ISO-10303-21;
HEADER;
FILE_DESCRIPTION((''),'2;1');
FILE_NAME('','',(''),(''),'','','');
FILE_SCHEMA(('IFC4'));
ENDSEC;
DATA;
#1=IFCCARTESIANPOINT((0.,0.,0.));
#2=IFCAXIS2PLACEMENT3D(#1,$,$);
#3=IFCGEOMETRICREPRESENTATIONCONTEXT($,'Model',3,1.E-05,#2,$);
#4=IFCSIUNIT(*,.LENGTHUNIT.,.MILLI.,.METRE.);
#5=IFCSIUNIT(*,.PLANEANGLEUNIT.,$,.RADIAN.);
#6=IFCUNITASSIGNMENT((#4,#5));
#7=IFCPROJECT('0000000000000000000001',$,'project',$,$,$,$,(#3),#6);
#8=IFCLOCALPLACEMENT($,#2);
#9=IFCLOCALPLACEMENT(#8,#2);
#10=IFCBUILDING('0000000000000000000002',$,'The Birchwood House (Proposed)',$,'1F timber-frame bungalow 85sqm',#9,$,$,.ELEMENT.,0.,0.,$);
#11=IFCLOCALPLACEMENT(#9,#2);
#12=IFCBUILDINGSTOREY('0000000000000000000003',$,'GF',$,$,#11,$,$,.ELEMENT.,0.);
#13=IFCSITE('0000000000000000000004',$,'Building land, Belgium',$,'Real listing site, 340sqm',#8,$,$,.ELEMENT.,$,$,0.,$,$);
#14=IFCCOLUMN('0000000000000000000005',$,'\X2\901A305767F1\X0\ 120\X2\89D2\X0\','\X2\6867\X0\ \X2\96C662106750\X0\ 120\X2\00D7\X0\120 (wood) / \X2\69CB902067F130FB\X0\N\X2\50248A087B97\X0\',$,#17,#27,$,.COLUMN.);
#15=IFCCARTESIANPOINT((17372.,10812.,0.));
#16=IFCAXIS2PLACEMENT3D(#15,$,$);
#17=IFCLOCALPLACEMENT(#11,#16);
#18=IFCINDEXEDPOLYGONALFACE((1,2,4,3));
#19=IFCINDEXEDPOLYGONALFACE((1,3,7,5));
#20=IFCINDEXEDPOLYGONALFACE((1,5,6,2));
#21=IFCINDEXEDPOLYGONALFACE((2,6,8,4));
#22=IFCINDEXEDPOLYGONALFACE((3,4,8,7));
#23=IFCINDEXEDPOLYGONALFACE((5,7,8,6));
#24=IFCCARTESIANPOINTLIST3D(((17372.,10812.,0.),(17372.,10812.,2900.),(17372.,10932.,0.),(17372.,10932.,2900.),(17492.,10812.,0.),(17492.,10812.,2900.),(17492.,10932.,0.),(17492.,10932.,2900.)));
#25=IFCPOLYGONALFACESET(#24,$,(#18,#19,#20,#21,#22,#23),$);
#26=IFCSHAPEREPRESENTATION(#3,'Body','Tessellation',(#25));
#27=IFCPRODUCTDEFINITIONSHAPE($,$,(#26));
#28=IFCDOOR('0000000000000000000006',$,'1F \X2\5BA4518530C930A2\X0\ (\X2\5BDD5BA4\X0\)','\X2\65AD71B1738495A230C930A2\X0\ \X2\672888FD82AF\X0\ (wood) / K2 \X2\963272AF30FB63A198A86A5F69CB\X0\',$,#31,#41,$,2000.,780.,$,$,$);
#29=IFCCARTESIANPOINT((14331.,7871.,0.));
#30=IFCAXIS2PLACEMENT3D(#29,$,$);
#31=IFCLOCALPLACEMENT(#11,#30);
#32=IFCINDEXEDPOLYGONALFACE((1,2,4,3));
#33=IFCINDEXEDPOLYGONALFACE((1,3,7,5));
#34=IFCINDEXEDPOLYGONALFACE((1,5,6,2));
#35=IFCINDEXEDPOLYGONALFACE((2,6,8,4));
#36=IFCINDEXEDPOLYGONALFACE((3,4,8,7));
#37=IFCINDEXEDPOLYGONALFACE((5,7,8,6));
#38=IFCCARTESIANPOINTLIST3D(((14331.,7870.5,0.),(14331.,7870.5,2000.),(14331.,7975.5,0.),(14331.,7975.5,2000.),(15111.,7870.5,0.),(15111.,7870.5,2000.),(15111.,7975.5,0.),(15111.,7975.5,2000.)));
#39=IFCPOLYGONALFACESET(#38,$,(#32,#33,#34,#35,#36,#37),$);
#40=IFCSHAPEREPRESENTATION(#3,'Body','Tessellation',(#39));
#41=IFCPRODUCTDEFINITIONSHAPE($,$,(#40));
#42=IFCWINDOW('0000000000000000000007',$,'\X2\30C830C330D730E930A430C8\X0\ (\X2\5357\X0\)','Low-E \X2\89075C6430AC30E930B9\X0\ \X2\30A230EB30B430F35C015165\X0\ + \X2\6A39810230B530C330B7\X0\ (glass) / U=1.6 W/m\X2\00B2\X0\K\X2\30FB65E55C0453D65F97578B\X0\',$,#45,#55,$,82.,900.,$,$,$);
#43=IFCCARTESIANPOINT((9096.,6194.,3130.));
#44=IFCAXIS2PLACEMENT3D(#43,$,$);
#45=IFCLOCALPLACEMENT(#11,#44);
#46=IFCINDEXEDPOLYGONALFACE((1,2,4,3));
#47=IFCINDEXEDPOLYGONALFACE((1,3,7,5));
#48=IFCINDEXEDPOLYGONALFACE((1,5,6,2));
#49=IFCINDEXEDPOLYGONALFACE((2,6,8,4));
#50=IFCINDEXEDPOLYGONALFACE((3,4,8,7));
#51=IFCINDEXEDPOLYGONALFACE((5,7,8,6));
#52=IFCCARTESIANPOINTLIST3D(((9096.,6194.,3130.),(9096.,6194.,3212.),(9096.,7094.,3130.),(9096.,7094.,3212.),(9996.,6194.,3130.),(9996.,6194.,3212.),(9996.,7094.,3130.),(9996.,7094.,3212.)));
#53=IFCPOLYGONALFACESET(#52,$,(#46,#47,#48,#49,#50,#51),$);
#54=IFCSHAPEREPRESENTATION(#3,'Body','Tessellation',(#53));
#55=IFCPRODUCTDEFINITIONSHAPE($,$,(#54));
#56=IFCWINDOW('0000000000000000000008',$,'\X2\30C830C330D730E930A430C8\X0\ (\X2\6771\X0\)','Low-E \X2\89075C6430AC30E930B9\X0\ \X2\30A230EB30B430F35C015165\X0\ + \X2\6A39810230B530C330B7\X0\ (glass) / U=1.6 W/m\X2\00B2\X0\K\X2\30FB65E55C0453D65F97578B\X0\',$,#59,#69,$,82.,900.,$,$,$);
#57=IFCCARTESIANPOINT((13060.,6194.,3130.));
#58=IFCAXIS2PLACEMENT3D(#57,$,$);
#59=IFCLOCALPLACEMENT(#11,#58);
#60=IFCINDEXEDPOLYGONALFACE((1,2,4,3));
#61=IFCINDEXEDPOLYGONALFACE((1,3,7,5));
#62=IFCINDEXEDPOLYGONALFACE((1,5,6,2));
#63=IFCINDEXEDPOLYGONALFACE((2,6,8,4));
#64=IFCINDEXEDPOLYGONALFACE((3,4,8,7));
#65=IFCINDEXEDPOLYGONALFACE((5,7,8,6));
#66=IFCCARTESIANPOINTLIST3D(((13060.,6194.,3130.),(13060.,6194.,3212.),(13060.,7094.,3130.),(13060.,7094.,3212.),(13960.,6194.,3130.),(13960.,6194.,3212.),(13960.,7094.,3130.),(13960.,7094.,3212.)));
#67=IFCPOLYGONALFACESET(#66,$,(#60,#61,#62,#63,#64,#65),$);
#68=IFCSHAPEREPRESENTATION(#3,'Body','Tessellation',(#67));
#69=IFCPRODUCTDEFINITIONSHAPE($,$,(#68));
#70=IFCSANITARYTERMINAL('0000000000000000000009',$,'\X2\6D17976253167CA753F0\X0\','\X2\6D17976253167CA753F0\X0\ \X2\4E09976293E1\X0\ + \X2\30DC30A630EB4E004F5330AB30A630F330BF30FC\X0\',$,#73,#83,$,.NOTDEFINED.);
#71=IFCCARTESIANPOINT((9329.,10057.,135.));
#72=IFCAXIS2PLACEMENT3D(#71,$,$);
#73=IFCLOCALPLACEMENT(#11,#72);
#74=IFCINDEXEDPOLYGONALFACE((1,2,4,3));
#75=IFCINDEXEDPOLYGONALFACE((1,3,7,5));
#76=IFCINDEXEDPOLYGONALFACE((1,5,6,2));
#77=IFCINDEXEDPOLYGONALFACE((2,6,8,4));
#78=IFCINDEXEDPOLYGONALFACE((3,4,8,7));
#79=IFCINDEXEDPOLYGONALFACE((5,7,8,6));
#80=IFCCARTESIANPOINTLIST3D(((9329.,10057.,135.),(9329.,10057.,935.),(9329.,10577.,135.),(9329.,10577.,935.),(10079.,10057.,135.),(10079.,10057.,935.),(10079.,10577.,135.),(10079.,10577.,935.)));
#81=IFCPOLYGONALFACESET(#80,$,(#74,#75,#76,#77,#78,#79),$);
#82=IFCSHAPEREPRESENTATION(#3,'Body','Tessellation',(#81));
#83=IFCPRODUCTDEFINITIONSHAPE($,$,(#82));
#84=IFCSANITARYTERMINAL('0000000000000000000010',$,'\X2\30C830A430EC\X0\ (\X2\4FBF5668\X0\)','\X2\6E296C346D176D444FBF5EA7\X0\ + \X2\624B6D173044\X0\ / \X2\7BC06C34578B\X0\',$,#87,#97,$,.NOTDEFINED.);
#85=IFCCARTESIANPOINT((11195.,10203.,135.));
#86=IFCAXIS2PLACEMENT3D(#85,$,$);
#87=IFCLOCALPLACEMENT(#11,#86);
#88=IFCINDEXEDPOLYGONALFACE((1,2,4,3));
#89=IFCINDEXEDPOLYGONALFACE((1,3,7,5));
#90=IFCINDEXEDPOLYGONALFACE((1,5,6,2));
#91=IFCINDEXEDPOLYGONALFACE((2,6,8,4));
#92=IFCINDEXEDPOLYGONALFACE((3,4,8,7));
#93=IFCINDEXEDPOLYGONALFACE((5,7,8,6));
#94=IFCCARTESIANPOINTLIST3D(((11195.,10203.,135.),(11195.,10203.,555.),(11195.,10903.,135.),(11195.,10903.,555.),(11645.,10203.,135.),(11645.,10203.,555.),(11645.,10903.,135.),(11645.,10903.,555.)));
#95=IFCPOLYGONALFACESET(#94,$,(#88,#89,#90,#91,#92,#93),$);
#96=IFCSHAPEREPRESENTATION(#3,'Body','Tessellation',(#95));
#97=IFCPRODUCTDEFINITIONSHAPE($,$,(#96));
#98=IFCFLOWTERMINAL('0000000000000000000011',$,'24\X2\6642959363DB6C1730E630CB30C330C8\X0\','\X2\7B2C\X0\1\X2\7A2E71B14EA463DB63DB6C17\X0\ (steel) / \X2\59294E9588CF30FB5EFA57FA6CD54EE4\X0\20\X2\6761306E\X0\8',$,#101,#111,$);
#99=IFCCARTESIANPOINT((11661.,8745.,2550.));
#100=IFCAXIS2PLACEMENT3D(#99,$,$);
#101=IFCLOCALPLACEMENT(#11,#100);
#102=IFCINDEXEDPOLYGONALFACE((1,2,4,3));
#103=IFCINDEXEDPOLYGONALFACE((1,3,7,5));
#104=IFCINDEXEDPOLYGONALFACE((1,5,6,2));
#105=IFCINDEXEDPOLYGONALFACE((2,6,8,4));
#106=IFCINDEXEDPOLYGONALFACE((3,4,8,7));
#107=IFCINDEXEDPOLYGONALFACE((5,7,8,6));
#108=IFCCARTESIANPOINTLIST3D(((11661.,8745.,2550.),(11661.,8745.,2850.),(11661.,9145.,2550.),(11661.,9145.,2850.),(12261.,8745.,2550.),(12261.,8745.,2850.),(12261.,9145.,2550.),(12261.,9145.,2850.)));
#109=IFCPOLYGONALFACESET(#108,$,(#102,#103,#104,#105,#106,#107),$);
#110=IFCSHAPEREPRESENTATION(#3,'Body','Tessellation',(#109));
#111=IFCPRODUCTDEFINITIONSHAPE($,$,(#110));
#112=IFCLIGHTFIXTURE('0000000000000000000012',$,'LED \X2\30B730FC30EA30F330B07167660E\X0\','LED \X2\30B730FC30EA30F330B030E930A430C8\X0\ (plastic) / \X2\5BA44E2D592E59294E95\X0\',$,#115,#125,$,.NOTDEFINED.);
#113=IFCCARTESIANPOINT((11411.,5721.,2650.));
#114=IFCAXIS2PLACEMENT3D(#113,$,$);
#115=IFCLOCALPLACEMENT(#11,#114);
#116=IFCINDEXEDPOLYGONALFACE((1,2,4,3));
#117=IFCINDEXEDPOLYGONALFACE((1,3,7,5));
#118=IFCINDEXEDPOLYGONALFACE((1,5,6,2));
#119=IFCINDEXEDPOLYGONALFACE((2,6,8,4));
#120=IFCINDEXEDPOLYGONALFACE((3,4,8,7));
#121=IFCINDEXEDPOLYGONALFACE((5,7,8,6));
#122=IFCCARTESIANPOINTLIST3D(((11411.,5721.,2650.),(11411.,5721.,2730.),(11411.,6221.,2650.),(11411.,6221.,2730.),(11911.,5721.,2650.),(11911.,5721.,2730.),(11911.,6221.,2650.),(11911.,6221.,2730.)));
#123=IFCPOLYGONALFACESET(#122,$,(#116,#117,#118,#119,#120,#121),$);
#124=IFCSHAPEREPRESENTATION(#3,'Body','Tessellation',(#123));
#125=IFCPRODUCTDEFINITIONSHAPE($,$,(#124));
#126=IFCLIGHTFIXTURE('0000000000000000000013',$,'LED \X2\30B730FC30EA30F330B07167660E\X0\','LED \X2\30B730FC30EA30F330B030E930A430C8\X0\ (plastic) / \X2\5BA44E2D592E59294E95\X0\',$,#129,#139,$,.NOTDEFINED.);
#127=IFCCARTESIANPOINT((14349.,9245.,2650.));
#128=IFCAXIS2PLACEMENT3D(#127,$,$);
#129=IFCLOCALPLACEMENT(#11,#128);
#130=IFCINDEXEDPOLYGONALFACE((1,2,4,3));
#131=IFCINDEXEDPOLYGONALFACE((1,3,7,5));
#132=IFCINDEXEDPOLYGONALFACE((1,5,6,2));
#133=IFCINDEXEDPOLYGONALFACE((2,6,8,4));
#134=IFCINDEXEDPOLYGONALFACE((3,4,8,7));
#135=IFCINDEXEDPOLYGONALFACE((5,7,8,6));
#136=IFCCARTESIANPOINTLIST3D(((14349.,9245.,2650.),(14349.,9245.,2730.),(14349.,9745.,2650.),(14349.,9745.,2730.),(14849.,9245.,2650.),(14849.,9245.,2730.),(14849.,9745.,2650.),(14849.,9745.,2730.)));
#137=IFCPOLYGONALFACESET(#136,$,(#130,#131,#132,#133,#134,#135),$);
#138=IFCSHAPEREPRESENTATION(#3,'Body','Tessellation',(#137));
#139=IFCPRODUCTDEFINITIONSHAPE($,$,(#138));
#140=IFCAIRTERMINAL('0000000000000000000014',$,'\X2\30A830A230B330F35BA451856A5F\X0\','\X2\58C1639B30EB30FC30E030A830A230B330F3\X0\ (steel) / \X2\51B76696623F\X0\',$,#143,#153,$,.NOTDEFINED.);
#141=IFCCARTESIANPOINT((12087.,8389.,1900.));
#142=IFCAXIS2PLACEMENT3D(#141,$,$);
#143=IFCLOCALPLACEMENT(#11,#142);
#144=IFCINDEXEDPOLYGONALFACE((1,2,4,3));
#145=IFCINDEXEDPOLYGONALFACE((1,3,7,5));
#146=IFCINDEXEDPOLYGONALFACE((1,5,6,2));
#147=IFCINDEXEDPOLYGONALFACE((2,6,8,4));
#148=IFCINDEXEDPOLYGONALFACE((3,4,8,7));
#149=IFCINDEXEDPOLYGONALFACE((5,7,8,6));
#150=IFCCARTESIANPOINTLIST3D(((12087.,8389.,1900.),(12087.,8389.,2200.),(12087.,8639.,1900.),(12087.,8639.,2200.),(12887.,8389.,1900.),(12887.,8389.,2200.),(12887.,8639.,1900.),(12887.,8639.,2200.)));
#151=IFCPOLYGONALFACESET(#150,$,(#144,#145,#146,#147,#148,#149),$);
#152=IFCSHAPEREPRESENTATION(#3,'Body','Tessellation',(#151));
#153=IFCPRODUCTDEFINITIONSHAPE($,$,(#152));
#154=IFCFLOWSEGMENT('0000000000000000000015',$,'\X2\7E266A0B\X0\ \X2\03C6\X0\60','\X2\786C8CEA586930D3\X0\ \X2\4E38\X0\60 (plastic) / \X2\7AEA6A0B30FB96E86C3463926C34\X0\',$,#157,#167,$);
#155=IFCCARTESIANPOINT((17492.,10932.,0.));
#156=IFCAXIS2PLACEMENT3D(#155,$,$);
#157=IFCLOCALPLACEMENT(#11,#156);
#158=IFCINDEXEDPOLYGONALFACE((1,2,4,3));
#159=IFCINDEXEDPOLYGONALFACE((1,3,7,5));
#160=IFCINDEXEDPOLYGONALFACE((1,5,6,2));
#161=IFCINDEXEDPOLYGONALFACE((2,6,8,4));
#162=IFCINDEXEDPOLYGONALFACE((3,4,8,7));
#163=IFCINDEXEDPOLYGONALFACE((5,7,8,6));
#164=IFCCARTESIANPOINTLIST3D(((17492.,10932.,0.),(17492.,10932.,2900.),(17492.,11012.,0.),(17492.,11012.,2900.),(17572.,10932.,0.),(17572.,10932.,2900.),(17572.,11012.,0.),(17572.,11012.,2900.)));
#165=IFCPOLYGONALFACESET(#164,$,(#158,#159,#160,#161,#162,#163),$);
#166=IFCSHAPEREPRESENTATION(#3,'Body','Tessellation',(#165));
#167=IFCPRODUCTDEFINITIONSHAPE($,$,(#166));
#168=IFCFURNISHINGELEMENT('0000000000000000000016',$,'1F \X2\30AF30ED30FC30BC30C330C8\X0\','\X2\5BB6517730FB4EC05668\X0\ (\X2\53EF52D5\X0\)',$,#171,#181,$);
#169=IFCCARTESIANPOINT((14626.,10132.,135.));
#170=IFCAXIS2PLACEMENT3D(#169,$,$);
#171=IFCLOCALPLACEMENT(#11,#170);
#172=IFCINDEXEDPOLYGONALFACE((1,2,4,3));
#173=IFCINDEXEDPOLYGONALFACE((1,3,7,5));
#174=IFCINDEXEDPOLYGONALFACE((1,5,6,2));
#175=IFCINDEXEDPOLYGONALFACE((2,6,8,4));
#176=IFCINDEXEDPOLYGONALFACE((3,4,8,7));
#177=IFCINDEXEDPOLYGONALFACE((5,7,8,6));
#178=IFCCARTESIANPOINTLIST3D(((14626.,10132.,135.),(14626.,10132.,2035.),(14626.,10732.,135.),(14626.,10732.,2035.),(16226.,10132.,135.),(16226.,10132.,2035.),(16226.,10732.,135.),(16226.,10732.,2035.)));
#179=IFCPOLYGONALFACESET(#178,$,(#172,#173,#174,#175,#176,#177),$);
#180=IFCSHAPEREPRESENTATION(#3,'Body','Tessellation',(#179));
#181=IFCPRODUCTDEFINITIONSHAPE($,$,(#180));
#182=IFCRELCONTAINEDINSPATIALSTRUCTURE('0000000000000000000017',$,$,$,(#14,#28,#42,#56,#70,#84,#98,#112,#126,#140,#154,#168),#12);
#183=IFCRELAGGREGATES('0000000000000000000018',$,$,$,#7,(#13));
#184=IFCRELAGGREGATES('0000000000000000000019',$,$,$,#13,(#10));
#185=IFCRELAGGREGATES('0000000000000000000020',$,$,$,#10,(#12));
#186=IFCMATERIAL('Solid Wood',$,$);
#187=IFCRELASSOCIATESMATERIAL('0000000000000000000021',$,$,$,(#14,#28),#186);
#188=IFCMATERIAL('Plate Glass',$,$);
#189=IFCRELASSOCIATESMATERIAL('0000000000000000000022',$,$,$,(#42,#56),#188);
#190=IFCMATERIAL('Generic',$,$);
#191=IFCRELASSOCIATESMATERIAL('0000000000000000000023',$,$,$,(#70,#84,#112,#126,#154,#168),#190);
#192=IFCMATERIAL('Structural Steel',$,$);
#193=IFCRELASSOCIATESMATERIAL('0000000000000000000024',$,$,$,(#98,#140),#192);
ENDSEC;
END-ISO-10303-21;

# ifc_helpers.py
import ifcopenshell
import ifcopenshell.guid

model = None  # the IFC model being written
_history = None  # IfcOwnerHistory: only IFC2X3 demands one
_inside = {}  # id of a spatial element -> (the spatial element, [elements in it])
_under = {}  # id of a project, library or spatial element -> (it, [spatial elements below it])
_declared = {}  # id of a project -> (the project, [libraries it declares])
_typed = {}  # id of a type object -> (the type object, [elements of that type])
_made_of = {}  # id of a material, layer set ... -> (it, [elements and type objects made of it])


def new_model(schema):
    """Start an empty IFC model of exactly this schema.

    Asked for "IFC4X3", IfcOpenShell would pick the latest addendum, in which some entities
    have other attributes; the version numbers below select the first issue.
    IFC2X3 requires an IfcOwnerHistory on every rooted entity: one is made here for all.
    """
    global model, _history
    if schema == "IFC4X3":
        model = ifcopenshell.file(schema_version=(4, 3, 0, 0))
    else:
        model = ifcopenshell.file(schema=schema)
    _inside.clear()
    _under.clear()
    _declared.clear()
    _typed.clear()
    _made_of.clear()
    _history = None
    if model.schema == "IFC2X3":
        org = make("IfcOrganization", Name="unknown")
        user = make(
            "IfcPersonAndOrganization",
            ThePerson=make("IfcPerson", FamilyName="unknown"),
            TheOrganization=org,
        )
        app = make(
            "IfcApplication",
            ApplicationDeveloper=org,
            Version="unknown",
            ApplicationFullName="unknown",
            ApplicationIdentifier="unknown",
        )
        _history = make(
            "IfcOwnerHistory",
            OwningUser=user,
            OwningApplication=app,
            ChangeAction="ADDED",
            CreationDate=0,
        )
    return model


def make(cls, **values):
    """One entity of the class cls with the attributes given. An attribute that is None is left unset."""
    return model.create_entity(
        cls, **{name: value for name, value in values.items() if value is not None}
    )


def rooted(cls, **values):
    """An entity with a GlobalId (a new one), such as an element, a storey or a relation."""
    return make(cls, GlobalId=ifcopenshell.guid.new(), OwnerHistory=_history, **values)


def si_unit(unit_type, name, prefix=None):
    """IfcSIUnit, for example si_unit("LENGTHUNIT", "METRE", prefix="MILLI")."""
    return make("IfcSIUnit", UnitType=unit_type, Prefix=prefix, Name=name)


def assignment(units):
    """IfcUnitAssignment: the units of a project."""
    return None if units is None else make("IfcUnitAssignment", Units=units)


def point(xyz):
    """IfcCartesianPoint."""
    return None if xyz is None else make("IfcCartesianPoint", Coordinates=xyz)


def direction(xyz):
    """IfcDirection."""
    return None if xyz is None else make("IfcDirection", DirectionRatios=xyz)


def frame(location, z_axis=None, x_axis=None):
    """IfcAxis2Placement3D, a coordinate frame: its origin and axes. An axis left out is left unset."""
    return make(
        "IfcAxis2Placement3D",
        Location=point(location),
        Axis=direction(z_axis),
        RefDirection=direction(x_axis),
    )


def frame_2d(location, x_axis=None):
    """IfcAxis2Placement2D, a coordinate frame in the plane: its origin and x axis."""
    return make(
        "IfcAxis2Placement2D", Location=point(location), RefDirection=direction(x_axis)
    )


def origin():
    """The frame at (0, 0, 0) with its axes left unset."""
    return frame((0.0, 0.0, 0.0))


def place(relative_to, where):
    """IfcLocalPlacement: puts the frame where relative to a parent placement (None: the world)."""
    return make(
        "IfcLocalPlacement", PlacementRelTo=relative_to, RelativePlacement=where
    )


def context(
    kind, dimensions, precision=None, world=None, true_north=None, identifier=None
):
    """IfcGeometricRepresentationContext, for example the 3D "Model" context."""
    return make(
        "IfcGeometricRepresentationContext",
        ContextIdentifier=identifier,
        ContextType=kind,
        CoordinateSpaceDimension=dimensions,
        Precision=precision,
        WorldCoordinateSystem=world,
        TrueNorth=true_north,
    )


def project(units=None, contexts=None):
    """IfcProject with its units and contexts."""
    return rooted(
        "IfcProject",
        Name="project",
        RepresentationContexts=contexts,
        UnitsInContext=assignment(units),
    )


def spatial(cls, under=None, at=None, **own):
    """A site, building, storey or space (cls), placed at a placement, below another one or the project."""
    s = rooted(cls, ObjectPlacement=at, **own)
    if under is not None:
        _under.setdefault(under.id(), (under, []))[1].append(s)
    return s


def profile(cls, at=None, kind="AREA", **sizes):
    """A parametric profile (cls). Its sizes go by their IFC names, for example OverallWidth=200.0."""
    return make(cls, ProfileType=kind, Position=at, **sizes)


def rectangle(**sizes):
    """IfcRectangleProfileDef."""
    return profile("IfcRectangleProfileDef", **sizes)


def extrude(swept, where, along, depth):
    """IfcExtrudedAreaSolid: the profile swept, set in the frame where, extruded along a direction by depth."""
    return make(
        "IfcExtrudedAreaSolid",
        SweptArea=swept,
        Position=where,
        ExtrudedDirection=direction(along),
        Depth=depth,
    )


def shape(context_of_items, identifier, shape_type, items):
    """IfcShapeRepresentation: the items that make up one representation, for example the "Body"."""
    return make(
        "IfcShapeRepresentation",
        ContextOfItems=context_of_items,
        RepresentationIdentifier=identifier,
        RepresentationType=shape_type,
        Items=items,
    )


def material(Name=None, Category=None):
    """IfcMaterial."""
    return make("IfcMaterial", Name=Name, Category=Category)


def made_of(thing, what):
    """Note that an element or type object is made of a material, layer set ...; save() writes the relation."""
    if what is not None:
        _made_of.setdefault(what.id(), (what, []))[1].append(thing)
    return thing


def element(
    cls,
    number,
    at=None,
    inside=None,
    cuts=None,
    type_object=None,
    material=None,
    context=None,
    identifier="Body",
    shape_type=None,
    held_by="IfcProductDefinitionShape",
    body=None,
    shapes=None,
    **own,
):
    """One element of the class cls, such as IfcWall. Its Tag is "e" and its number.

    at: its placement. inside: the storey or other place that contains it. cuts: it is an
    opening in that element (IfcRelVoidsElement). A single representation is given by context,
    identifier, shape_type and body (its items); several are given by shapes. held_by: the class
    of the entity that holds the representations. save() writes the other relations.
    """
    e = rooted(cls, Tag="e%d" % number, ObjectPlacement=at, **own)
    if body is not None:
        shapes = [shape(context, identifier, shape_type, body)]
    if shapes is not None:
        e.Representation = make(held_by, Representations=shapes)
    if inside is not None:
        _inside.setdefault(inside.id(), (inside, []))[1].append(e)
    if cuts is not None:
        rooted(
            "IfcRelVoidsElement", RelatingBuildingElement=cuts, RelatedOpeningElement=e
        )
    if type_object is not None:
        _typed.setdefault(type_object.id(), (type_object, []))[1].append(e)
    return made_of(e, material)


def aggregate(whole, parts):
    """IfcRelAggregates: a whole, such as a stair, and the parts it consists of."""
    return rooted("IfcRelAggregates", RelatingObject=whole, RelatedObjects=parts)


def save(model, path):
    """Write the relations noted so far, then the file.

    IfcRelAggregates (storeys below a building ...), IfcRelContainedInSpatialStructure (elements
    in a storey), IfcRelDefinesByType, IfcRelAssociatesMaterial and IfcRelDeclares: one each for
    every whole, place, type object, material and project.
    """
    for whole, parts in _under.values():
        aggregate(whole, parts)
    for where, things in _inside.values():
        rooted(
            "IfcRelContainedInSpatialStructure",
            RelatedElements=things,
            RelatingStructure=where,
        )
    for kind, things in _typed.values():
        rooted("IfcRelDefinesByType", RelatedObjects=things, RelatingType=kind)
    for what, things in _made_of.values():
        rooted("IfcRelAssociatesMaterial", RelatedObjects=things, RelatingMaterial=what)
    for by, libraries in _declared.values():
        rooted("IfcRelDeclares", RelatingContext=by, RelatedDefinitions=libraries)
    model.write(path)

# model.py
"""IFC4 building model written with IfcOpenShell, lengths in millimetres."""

from ifc_helpers import new_model, si_unit, frame, frame_2d, origin, place, context, project, spatial, rectangle, extrude, material, element, save


model = new_model("IFC4")

# Units and contexts
model_context = context("Model", 3, precision=1e-05, world=origin())
ifc_project = project(units=[si_unit("LENGTHUNIT", "METRE", prefix="MILLI"), si_unit("PLANEANGLEUNIT", "RADIAN")], contexts=[model_context])

# Site, building, storey
site_placement = place(None, origin())
site = spatial("IfcSite", under=ifc_project, at=site_placement, Name="Building land, Belgium", ObjectType="Real listing site, 340sqm", CompositionType="ELEMENT", RefElevation=0.0)
building_placement = place(site_placement, origin())
building = spatial("IfcBuilding", under=site, at=building_placement, Name="The Birchwood House (Proposed)", ObjectType="1F timber-frame bungalow 85sqm", CompositionType="ELEMENT", ElevationOfRefHeight=0.0, ElevationOfTerrain=0.0)
storey_placement = place(building_placement, origin())
storey = spatial("IfcBuildingStorey", under=building, at=storey_placement, Name="GF", CompositionType="ELEMENT", Elevation=0.0)

# Column
ifc_material_1 = material(Name="Solid Wood")
column_1_placement = place(storey_placement, frame((17372.0, 10812.0, 0.0)))
element("IfcColumn", 1, at=column_1_placement, inside=storey, material=ifc_material_1, Name="通し柱 120角", Description="桧 集成材 120×120 (wood) / 構造柱・N値計算", PredefinedType="COLUMN", context=model_context, shape_type="SweptSolid", body=[
    extrude(rectangle(XDim=120.0, YDim=120.0, at=frame_2d((60.0, 60.0))), frame((17372.0, 10812.0, 0.0)), (0.0, 0.0, 1.0), 2900.0),
])

# Door
door_placement = place(storey_placement, frame((14331.0, 7871.0, 0.0)))
element("IfcDoor", 2, at=door_placement, inside=storey, material=ifc_material_1, Name="1F 室内ドア (寝室)", Description="断熱玄関ドア 木製芯 (wood) / K2 防犯・採風機構", OverallHeight=2000.0, OverallWidth=780.0, context=model_context, shape_type="SweptSolid", body=[
    extrude(rectangle(XDim=780.0, YDim=105.0, at=frame_2d((390.0, 52.0))), frame((14331.0, 7871.0, 0.0)), (0.0, 0.0, 1.0), 2000.0),
])

# Windows
ifc_material_2 = material(Name="Plate Glass")
window_1_placement = place(storey_placement, frame((9096.0, 6194.0, 3130.0)))
element("IfcWindow", 3, at=window_1_placement, inside=storey, material=ifc_material_2, Name="トップライト (南)", Description="Low-E 複層ガラス アルゴン封入 + 樹脂サッシ (glass) / U=1.6 W/m²K・日射取得型", OverallHeight=82.0, OverallWidth=900.0, context=model_context, shape_type="SweptSolid", body=[
    extrude(rectangle(XDim=900.0, YDim=900.0, at=frame_2d((450.0, 450.0))), frame((9096.0, 6194.0, 3130.0)), (0.0, 0.0, 1.0), 82.0),
])
window_2_placement = place(storey_placement, frame((13060.0, 6194.0, 3130.0)))
element("IfcWindow", 4, at=window_2_placement, inside=storey, material=ifc_material_2, Name="トップライト (東)", Description="Low-E 複層ガラス アルゴン封入 + 樹脂サッシ (glass) / U=1.6 W/m²K・日射取得型", OverallHeight=82.0, OverallWidth=900.0, context=model_context, shape_type="SweptSolid", body=[
    extrude(rectangle(XDim=900.0, YDim=900.0, at=frame_2d((450.0, 450.0))), frame((13060.0, 6194.0, 3130.0)), (0.0, 0.0, 1.0), 82.0),
])

# Sanitary terminals
ifc_material_3 = material(Name="Generic")
sanitary_terminal_1_placement = place(storey_placement, frame((9329.0, 10057.0, 135.0)))
element("IfcSanitaryTerminal", 5, at=sanitary_terminal_1_placement, inside=storey, material=ifc_material_3, Name="洗面化粧台", Description="洗面化粧台 三面鏡 + ボウル一体カウンター", PredefinedType="NOTDEFINED", context=model_context, shape_type="SweptSolid", body=[
    extrude(rectangle(XDim=750.0, YDim=520.0, at=frame_2d((375.0, 260.0))), frame((9329.0, 10057.0, 135.0)), (0.0, 0.0, 1.0), 800.0),
])
sanitary_terminal_2_placement = place(storey_placement, frame((11195.0, 10203.0, 135.0)))
element("IfcSanitaryTerminal", 6, at=sanitary_terminal_2_placement, inside=storey, material=ifc_material_3, Name="トイレ (便器)", Description="温水洗浄便座 + 手洗い / 節水型", PredefinedType="NOTDEFINED", context=model_context, shape_type="SweptSolid", body=[
    extrude(rectangle(XDim=450.0, YDim=700.0, at=frame_2d((225.0, 350.0))), frame((11195.0, 10203.0, 135.0)), (0.0, 0.0, 1.0), 420.0),
])

# Flow terminal
ifc_material_4 = material(Name="Structural Steel")
flow_terminal_placement = place(storey_placement, frame((11661.0, 8745.0, 2550.0)))
element("IfcFlowTerminal", 7, at=flow_terminal_placement, inside=storey, material=ifc_material_4, Name="24時間換気ユニット", Description="第1種熱交換換気 (steel) / 天井裏・建基法令20条の8", context=model_context, shape_type="SweptSolid", body=[
    extrude(rectangle(XDim=600.0, YDim=400.0, at=frame_2d((300.0, 200.0))), frame((11661.0, 8745.0, 2550.0)), (0.0, 0.0, 1.0), 300.0),
])

# Light fixtures
light_fixture_1_placement = place(storey_placement, frame((11411.0, 5721.0, 2650.0)))
element("IfcLightFixture", 8, at=light_fixture_1_placement, inside=storey, material=ifc_material_3, Name="LED シーリング照明", Description="LED シーリングライト (plastic) / 室中央天井", PredefinedType="NOTDEFINED", context=model_context, shape_type="SweptSolid", body=[
    extrude(rectangle(XDim=500.0, YDim=500.0, at=frame_2d((250.0, 250.0))), frame((11411.0, 5721.0, 2650.0)), (0.0, 0.0, 1.0), 80.0),
])
light_fixture_2_placement = place(storey_placement, frame((14349.0, 9245.0, 2650.0)))
element("IfcLightFixture", 9, at=light_fixture_2_placement, inside=storey, material=ifc_material_3, Name="LED シーリング照明", Description="LED シーリングライト (plastic) / 室中央天井", PredefinedType="NOTDEFINED", context=model_context, shape_type="SweptSolid", body=[
    extrude(rectangle(XDim=500.0, YDim=500.0, at=frame_2d((250.0, 250.0))), frame((14349.0, 9245.0, 2650.0)), (0.0, 0.0, 1.0), 80.0),
])

# Air terminal
air_terminal_placement = place(storey_placement, frame((12087.0, 8389.0, 1900.0)))
element("IfcAirTerminal", 10, at=air_terminal_placement, inside=storey, material=ifc_material_4, Name="エアコン室内機", Description="壁掛ルームエアコン (steel) / 冷暖房", PredefinedType="NOTDEFINED", context=model_context, shape_type="SweptSolid", body=[
    extrude(rectangle(XDim=800.0, YDim=250.0, at=frame_2d((400.0, 125.0))), frame((12087.0, 8389.0, 1900.0)), (0.0, 0.0, 1.0), 300.0),
])

# Flow segment
flow_segment_placement = place(storey_placement, frame((17492.0, 10932.0, 0.0)))
element("IfcFlowSegment", 11, at=flow_segment_placement, inside=storey, material=ifc_material_3, Name="縦樋 φ60", Description="硬質塩ビ 丸60 (plastic) / 竪樋・雨水排水", context=model_context, shape_type="SweptSolid", body=[
    extrude(rectangle(XDim=80.0, YDim=80.0, at=frame_2d((40.0, 40.0))), frame((17492.0, 10932.0, 0.0)), (0.0, 0.0, 1.0), 2900.0),
])

# Furnishing element
furnishing_placement = place(storey_placement, frame((14626.0, 10132.0, 135.0)))
element("IfcFurnishingElement", 12, at=furnishing_placement, inside=storey, material=ifc_material_3, Name="1F クローゼット", Description="家具・什器 (可動)", context=model_context, shape_type="SweptSolid", body=[
    extrude(rectangle(XDim=1600.0, YDim=600.0, at=frame_2d((800.0, 300.0))), frame((14626.0, 10132.0, 135.0)), (0.0, 0.0, 1.0), 1900.0),
])

save(model, "model.ifc")
